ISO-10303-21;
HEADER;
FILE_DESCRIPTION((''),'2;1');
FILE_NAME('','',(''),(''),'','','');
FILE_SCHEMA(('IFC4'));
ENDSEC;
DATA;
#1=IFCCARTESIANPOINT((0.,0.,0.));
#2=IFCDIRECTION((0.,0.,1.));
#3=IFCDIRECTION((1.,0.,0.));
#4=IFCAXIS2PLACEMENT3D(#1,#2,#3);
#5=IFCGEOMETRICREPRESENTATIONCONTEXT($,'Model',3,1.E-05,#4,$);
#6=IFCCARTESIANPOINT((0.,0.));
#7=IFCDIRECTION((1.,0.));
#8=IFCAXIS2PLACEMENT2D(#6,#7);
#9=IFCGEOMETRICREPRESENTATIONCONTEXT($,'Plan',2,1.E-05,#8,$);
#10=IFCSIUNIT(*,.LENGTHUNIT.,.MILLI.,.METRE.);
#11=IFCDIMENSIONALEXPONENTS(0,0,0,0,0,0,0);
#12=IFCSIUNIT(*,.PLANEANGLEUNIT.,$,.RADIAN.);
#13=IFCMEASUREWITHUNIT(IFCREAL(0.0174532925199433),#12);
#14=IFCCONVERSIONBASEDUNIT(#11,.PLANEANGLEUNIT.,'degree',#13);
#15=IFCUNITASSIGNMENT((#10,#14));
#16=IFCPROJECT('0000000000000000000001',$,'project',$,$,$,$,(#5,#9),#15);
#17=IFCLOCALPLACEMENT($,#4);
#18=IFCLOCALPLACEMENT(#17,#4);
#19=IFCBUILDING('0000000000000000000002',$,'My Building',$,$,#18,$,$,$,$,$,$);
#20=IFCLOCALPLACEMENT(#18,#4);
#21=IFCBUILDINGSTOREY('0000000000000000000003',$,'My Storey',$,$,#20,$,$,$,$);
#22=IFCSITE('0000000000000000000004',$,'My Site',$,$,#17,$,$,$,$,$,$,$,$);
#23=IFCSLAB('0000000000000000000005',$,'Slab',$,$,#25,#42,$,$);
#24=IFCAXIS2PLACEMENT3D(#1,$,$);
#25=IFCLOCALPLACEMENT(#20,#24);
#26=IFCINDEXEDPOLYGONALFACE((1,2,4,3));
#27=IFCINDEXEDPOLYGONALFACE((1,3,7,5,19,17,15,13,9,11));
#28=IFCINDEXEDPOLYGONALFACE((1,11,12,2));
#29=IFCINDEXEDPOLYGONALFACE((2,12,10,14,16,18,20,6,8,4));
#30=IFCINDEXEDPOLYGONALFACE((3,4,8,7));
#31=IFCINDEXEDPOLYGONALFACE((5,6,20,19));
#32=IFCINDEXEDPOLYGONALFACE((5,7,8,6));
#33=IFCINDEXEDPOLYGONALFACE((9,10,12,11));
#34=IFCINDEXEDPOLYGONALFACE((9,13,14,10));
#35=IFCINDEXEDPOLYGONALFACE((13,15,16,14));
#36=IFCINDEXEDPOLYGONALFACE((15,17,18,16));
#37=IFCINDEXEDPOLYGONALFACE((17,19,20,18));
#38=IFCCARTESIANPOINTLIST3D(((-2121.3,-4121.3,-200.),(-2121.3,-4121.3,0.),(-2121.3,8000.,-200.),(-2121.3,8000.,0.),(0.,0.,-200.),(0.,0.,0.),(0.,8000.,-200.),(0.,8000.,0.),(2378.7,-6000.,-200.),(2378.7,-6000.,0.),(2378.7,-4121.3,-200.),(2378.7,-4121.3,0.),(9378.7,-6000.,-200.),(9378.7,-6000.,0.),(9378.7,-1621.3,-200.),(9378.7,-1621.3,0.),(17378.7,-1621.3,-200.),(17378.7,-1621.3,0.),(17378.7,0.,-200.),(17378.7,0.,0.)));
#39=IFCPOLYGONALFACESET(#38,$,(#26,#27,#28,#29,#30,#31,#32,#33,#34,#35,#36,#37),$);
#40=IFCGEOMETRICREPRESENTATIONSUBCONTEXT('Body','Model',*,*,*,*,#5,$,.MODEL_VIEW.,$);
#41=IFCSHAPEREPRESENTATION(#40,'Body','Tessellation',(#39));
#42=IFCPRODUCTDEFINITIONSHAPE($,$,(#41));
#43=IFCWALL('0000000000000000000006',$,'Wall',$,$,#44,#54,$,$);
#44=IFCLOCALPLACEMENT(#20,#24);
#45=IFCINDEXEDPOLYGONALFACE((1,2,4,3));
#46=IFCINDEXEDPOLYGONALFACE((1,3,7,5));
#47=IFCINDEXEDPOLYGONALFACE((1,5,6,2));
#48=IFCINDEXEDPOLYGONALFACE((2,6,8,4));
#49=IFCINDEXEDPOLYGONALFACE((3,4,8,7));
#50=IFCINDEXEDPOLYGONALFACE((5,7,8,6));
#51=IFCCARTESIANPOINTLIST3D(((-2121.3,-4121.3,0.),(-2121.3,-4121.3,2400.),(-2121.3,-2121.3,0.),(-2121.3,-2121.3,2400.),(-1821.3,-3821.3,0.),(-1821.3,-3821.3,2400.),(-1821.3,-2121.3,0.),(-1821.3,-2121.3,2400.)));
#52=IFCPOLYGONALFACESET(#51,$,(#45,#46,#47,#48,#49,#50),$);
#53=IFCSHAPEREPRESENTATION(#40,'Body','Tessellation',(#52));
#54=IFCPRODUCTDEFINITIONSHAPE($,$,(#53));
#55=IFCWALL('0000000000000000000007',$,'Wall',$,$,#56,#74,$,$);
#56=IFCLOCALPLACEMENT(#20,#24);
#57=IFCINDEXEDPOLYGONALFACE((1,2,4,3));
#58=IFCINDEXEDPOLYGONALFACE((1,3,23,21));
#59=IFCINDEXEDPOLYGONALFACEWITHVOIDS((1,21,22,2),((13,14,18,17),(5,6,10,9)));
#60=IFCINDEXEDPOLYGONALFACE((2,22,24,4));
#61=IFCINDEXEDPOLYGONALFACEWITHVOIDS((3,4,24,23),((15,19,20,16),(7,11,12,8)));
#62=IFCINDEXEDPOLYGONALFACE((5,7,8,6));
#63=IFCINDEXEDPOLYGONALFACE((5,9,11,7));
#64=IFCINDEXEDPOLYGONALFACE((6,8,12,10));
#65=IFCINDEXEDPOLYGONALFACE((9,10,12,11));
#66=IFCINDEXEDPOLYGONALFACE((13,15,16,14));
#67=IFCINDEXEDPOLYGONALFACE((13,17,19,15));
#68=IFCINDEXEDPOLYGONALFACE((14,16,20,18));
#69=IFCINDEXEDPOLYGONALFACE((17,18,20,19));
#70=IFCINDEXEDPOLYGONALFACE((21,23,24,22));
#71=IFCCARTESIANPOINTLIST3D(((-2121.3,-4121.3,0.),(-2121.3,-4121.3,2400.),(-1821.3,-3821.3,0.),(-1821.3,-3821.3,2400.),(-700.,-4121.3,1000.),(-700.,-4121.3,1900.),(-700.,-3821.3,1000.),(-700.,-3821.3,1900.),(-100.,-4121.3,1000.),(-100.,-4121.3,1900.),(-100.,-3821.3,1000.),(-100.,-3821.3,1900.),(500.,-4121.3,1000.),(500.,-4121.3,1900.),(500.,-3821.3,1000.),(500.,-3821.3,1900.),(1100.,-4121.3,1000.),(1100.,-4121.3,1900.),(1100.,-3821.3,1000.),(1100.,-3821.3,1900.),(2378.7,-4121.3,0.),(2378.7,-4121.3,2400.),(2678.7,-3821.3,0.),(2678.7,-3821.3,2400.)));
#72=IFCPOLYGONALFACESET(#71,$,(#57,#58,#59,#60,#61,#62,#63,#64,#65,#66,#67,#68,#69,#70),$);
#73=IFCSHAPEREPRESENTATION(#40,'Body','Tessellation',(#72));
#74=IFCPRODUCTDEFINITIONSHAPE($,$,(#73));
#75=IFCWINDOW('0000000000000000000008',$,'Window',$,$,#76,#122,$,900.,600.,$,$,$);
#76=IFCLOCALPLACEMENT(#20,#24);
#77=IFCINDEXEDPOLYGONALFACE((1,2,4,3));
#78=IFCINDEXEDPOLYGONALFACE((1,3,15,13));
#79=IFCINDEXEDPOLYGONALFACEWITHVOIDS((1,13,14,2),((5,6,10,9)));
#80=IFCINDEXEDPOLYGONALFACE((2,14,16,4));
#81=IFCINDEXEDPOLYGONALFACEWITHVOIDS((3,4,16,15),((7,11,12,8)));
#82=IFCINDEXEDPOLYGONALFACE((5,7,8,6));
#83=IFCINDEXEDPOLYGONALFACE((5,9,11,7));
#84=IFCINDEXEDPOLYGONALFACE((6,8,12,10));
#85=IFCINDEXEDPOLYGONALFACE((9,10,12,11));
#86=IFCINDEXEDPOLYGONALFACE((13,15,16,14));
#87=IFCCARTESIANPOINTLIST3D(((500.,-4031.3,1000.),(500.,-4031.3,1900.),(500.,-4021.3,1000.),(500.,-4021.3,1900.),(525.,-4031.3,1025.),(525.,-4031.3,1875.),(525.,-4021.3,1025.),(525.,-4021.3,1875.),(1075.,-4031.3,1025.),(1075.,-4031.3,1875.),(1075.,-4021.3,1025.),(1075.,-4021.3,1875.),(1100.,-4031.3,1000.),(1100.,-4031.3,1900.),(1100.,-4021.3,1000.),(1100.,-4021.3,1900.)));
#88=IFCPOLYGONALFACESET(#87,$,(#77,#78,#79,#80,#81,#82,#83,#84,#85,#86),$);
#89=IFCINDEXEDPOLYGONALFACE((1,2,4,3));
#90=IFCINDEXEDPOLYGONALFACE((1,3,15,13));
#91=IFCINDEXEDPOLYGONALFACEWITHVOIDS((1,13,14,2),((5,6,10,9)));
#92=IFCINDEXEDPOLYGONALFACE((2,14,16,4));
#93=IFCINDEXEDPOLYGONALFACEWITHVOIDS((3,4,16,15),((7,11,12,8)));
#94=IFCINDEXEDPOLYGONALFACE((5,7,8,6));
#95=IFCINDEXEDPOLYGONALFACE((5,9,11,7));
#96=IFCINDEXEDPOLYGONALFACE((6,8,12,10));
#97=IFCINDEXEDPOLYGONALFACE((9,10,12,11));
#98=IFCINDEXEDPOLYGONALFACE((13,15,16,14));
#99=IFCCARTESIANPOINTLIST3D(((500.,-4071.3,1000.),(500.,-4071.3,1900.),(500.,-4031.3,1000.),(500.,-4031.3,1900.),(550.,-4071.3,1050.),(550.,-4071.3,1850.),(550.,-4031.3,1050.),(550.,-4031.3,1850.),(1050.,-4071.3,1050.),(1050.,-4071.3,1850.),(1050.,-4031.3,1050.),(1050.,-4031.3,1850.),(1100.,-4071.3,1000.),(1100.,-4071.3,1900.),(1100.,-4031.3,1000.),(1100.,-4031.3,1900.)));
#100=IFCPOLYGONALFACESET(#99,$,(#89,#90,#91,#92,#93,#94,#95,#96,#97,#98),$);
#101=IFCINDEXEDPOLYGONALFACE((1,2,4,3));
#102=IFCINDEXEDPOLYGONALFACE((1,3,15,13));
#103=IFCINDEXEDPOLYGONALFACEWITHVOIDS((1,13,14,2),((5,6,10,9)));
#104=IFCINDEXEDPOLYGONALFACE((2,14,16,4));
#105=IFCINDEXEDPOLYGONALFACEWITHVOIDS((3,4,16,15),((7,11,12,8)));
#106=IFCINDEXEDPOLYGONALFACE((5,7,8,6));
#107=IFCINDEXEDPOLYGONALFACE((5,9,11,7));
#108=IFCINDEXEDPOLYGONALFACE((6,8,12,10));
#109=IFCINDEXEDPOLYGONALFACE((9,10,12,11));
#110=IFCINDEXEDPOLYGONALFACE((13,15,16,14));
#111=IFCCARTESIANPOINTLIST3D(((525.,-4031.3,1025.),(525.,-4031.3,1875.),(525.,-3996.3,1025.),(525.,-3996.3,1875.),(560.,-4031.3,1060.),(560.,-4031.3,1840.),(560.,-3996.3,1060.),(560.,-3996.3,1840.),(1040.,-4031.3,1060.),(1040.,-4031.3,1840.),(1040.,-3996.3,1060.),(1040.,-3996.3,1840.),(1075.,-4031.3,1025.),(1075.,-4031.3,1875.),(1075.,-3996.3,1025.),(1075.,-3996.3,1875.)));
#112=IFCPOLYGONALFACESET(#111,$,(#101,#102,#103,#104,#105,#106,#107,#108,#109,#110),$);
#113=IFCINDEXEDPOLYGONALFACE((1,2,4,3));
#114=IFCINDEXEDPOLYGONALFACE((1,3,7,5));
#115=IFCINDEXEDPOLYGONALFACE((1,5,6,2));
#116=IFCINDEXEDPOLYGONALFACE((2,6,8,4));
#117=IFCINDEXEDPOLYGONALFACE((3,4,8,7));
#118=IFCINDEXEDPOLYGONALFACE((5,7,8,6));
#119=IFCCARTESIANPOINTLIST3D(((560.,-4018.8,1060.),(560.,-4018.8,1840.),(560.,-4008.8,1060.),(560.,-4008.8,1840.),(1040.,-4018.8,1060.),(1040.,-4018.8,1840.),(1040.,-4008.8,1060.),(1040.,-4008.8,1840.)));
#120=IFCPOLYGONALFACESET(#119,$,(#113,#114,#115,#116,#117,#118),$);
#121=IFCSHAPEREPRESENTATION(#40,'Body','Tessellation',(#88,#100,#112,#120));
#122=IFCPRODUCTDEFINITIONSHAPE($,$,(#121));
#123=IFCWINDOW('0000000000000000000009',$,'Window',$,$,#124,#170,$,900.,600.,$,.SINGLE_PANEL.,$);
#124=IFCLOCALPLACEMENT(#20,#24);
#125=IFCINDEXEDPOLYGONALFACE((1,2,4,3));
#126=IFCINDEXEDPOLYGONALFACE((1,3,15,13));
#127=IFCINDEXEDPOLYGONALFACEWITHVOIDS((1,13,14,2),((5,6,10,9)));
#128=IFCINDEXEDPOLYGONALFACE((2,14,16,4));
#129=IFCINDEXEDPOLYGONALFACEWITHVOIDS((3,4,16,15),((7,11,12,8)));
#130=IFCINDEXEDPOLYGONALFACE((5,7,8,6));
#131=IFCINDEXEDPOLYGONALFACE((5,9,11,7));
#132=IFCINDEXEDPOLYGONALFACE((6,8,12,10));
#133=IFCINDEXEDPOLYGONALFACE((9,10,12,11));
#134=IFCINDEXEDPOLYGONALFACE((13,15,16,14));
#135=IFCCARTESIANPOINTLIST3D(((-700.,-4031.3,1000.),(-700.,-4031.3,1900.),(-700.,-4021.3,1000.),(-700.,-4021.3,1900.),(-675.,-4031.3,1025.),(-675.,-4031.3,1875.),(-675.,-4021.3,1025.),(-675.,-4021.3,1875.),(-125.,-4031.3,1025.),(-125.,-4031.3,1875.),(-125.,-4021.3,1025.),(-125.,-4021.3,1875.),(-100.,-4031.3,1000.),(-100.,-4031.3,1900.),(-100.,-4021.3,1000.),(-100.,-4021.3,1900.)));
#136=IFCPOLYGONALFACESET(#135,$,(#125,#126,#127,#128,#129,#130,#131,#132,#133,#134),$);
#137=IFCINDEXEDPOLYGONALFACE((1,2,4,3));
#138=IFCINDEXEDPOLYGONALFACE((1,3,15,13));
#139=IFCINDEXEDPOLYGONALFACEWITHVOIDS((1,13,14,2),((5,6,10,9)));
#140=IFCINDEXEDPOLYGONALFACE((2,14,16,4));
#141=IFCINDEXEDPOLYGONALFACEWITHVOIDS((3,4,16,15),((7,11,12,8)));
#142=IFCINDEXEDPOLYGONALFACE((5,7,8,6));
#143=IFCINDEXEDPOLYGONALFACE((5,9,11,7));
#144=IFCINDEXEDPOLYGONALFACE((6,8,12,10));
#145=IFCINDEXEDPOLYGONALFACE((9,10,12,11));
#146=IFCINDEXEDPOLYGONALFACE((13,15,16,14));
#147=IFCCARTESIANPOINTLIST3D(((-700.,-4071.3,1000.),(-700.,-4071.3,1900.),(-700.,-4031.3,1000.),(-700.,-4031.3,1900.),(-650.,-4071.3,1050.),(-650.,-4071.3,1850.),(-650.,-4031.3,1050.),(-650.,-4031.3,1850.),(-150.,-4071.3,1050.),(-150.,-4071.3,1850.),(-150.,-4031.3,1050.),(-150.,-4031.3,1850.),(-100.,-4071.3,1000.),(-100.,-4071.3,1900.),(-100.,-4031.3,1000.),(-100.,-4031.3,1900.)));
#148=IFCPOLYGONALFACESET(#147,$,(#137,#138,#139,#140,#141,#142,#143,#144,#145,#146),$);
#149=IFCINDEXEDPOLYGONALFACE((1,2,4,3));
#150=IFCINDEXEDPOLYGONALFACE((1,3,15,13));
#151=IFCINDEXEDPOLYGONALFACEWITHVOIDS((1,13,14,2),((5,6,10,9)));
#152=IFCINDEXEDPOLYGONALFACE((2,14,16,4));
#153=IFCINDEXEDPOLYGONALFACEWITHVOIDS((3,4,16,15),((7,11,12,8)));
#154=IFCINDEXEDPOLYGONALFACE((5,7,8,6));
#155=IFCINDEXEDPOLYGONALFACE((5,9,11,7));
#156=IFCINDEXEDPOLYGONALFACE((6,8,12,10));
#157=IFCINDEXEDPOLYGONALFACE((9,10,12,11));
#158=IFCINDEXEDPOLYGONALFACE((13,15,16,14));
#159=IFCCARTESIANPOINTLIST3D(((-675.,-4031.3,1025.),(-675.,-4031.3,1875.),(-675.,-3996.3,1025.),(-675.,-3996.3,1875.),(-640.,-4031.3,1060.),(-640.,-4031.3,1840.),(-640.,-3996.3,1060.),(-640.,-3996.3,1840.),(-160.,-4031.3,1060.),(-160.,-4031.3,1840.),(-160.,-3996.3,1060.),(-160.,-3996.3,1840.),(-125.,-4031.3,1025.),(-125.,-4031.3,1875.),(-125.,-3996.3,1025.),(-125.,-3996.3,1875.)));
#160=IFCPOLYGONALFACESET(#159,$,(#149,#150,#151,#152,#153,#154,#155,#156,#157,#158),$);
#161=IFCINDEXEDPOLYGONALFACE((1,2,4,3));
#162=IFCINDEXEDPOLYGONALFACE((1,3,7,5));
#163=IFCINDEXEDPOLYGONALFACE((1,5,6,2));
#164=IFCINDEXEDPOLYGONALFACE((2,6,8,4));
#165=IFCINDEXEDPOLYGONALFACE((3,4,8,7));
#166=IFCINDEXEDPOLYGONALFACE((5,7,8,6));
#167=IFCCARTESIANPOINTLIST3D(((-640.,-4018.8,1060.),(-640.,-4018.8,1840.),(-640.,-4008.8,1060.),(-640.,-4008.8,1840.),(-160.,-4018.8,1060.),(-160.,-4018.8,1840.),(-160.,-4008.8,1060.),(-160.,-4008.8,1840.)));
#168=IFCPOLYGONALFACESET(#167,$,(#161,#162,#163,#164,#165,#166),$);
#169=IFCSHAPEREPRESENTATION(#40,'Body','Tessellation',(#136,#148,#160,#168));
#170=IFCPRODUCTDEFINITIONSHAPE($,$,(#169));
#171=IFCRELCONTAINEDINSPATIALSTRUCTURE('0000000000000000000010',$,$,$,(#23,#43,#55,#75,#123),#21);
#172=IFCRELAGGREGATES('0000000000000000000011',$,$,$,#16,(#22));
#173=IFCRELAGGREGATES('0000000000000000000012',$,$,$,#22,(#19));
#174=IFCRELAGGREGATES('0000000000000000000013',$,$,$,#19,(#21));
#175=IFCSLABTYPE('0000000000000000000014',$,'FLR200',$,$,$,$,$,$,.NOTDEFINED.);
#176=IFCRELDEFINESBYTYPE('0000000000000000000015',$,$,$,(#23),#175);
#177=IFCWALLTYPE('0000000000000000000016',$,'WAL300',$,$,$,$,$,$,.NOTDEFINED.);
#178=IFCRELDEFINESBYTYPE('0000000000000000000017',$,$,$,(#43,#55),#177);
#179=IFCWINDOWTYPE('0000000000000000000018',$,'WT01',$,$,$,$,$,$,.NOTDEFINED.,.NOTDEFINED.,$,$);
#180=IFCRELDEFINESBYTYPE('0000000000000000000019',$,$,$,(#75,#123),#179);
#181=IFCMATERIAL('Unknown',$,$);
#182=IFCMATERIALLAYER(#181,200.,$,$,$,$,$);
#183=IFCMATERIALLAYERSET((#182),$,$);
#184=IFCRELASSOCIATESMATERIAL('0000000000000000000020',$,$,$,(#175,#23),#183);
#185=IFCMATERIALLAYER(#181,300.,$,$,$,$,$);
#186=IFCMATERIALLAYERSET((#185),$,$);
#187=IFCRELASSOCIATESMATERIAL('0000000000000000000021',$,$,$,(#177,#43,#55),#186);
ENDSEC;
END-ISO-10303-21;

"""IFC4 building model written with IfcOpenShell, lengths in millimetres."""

from ifc_helpers import new_model, entity, si_unit, converted_unit, frame, origin_with_axes, origin_2d_with_axis, place, context, subcontext, project, spatial, line, indexed_curve, outline, extrude, shape, source, transform, mapped, material, layer, layer_set, layer_usage, type_object, type_shapes, element, fill, save


model = new_model("IFC4")

# Units and contexts
model_context = context("Model", 3, precision=1e-05, world=origin_with_axes())
plan_context = context("Plan", 2, precision=1e-05, world=origin_2d_with_axis())
body_context_1 = subcontext(model_context, "Body", "Model", "MODEL_VIEW")
body_context_2 = subcontext(plan_context, "Body", "Plan", "PLAN_VIEW")
ifc_project = project(units=[si_unit("LENGTHUNIT", "METRE", prefix="MILLI"), converted_unit("PLANEANGLEUNIT", "degree", entity("IfcReal", 0.0174532925199433), si_unit("PLANEANGLEUNIT", "RADIAN"), dimensions=[0, 0, 0, 0, 0, 0, 0])], contexts=[model_context, plan_context])

# Site, building, storey
site_placement = place(None, origin_with_axes())
site = spatial("IfcSite", under=ifc_project, at=site_placement, Name="My Site")
building_placement = place(site_placement, origin_with_axes())
building = spatial("IfcBuilding", under=site, at=building_placement, Name="My Building")
storey_placement = place(building_placement, origin_with_axes())
storey = spatial("IfcBuildingStorey", under=building, at=storey_placement, Name="My Storey")

# Shared definitions
ifc_material = material(Name="Unknown")

# Slab
ifc_layer_1 = layer(ifc_material, 200.0)
ifc_layer_set_1 = layer_set([ifc_layer_1])
ifc_layer_usage_1 = layer_usage(ifc_layer_set_1, "AXIS3", "POSITIVE", -200.0)
slab_type = type_object("IfcSlabType", Name="FLR200", PredefinedType="NOTDEFINED", material=ifc_layer_set_1)
slab_placement = place(storey_placement, frame((0.0, 8000.0, 0.0), z_axis=(0.0, 0.0, 1.0), x_axis=(1.0, 0.0, 0.0)))
element("IfcSlab", 1, at=slab_placement, inside=storey, type_object=slab_type, material=ifc_layer_usage_1, Name="Slab", context=body_context_1, shape_type="SweptSolid", body=[
    extrude(outline(indexed_curve([(0.0, 0.0), (-2121.3, 0.0), (-2121.3, -12121.3), (2378.7, -12121.3), (2378.7, -14000.0), (9378.7, -14000.0), (9378.7, -9621.3), (17378.7, -9621.3), (17378.7, -8000.0), (0.0, -8000.0), (0.0, 0.0)])), frame((0.0, 0.0, -200.0), z_axis=(0.0, 0.0, 1.0), x_axis=(1.0, 0.0, 0.0)), (0.0, 0.0, 1.0), 200.0),
])

# Wall
ifc_layer_2 = layer(ifc_material, 300.0)
ifc_layer_set_2 = layer_set([ifc_layer_2])
ifc_layer_usage_2 = layer_usage(ifc_layer_set_2, "AXIS2", "POSITIVE", 0.0)
wall_type = type_object("IfcWallType", Name="WAL300", PredefinedType="NOTDEFINED", material=ifc_layer_set_2)
wall_1_placement = place(storey_placement, frame((-2121.3, -2121.3, 0.0), z_axis=(0.0, 0.0, 1.0), x_axis=(0.0, -1.0, 0.0)))
element("IfcWall", 2, at=wall_1_placement, inside=storey, type_object=wall_type, material=ifc_layer_usage_2, Name="Wall", context=body_context_1, shape_type="SweptSolid", body=[
    extrude(outline(indexed_curve([(0.0, 0.0), (0.0, 300.0), (1700.0, 300.0), (2000.0, 0.0)], segments=[line(1, 2, 3, 4, 1)])), origin_with_axes(), (0.0, 0.0, 1.0), 2400.0),
])

# Wall, openings, windows
ifc_layer_usage_3 = layer_usage(ifc_layer_set_2, "AXIS2", "POSITIVE", 0.0)
wall_2_placement = place(storey_placement, frame((-2121.3, -4121.3, 0.0), z_axis=(0.0, 0.0, 1.0), x_axis=(1.0, 0.0, 0.0)))
wall_2 = element("IfcWall", 3, at=wall_2_placement, inside=storey, type_object=wall_type, material=ifc_layer_usage_3, Name="Wall", context=body_context_1, shape_type="SweptSolid", body=[
    extrude(outline(indexed_curve([(0.0, 0.0), (300.0, 300.0), (4800.0, 300.0), (4500.0, 0.0)], segments=[line(1, 2, 3, 4, 1)])), origin_with_axes(), (0.0, 0.0, 1.0), 2400.0),
])
shared_shape_1 = source(origin_with_axes(), body_context_1, "Body", "SweptSolid", [
    extrude(outline(indexed_curve([(0.0, 0.0), (600.0, 0.0), (600.0, 900.0), (0.0, 900.0)], segments=[line(1, 2, 3, 4, 1)])), frame((0.0, -600.0, 0.0), z_axis=(0.0, -1.0, 0.0), x_axis=(1.0, 0.0, 0.0)), (0.0, 0.0, -1.0), 1200.0),
])
opening_1_placement = place(wall_2_placement, frame((2621.3, 0.0, 1000.0), z_axis=(0.0, 0.0, 1.0), x_axis=(1.0, 0.0, 0.0)))
opening_1 = element("IfcOpeningElement", 4, at=opening_1_placement, cuts=wall_2, PredefinedType="OPENING", context=body_context_1, shape_type="MappedRepresentation", body=[
    mapped(shared_shape_1, transform((0.0, 0.0, 0.0), x_axis=(1.0, 0.0, 0.0), y_axis=(0.0, 1.0, 0.0), z_axis=(0.0, 0.0, 1.0), scale=1.0)),
])
opening_2_placement = place(wall_2_placement, frame((1421.3, 0.0, 1000.0), z_axis=(0.0, 0.0, 1.0), x_axis=(1.0, 0.0, 0.0)))
opening_2 = element("IfcOpeningElement", 5, at=opening_2_placement, cuts=wall_2, PredefinedType="OPENING", context=body_context_1, shape_type="MappedRepresentation", body=[
    mapped(shared_shape_1, transform((0.0, 0.0, 0.0), x_axis=(1.0, 0.0, 0.0), y_axis=(0.0, 1.0, 0.0), z_axis=(0.0, 0.0, 1.0), scale=1.0)),
])
window_type = type_object("IfcWindowType", Name="WT01", PartitioningType="NOTDEFINED", PredefinedType="NOTDEFINED")
shared_shape_2 = source(origin_with_axes(), body_context_1, "Body", "SweptSolid", [
    extrude(outline(indexed_curve([(0.0, 0.0), (600.0, 0.0), (600.0, 900.0), (0.0, 900.0)], segments=[line(1, 2, 3, 4, 1)]), holes=[indexed_curve([(25.0, 25.0), (575.0, 25.0), (575.0, 875.0), (25.0, 875.0)], segments=[line(1, 2, 3, 4, 1)])]), frame((0.0, 90.0, 0.0), z_axis=(0.0, -1.0, 0.0), x_axis=(1.0, 0.0, 0.0)), (0.0, 0.0, -1.0), 10.0),
    extrude(outline(indexed_curve([(0.0, 0.0), (600.0, 0.0), (600.0, 900.0), (0.0, 900.0)], segments=[line(1, 2, 3, 4, 1)]), holes=[indexed_curve([(50.0, 50.0), (550.0, 50.0), (550.0, 850.0), (50.0, 850.0)], segments=[line(1, 2, 3, 4, 1)])]), frame((0.0, 50.0, 0.0), z_axis=(0.0, -1.0, 0.0), x_axis=(1.0, 0.0, 0.0)), (0.0, 0.0, -1.0), 40.0),
    extrude(outline(indexed_curve([(0.0, 0.0), (550.0, 0.0), (550.0, 850.0), (0.0, 850.0), (0.0, 0.0)]), holes=[indexed_curve([(35.0, 35.0), (515.0, 35.0), (515.0, 815.0), (35.0, 815.0), (35.0, 35.0)])]), frame((25.0, 90.0, 25.0), z_axis=(0.0, -1.0, 0.0), x_axis=(1.0, 0.0, 0.0)), (0.0, 0.0, -1.0), 35.0),
    extrude(outline(indexed_curve([(35.0, 815.0), (515.0, 815.0), (515.0, 35.0), (35.0, 35.0), (35.0, 815.0)])), frame((25.0, 102.5, 25.0), z_axis=(0.0, -1.0, 0.0), x_axis=(1.0, 0.0, 0.0)), (0.0, 0.0, -1.0), 10.0),
])
shared_shape_3 = source(origin_with_axes(), body_context_2, "Body", "Curve2D", [
    entity("IfcIndexedPolyCurve", entity("IfcCartesianPointList2D", [[50.0, 50.0], [550.0, 50.0]])),
    entity("IfcIndexedPolyCurve", entity("IfcCartesianPointList2D", [[0.0, 100.0], [25.0, 100.0], [25.0, 90.0], [50.0, 90.0], [50.0, 50.0], [0.0, 50.0]]), [entity("IfcLineIndex", [1, 2, 3, 4, 5, 6, 1])]),
    entity("IfcIndexedPolyCurve", entity("IfcCartesianPointList2D", [[600.0, 100.0], [575.0, 100.0], [575.0, 90.0], [550.0, 90.0], [550.0, 50.0], [600.0, 50.0]]), [entity("IfcLineIndex", [1, 2, 3, 4, 5, 6, 1])]),
    entity("IfcIndexedPolyCurve", entity("IfcCartesianPointList2D", [[25.0, 90.0], [60.0, 90.0], [60.0, 125.0], [25.0, 125.0]]), [entity("IfcLineIndex", [1, 2, 3, 4, 1])]),
    entity("IfcIndexedPolyCurve", entity("IfcCartesianPointList2D", [[575.0, 90.0], [540.0, 90.0], [540.0, 125.0], [575.0, 125.0]]), [entity("IfcLineIndex", [1, 2, 3, 4, 1])]),
    entity("IfcIndexedPolyCurve", entity("IfcCartesianPointList2D", [[60.0, 90.0], [540.0, 90.0]])),
    entity("IfcIndexedPolyCurve", entity("IfcCartesianPointList2D", [[60.0, 125.0], [540.0, 125.0]])),
    entity("IfcIndexedPolyCurve", entity("IfcCartesianPointList2D", [[60.0, 107.5], [540.0, 107.5]])),
])
type_shapes(window_type, [shared_shape_2, shared_shape_3])
window_1_placement = place(opening_1_placement, frame((0.0, 0.0, 0.0), z_axis=(0.0, 0.0, 1.0), x_axis=(1.0, 0.0, 0.0)))
window_1 = element("IfcWindow", 6, at=window_1_placement, inside=storey, type_object=window_type, Name="Window", OverallHeight=900.0, OverallWidth=600.0, shapes=[
    shape(body_context_1, "Body", "MappedRepresentation", [mapped(shared_shape_2, transform((0.0, 0.0, 0.0), x_axis=(1.0, 0.0, 0.0), y_axis=(0.0, 1.0, 0.0), z_axis=(0.0, 0.0, 1.0), scale=1.0))]),
    shape(body_context_2, "Body", "MappedRepresentation", [mapped(shared_shape_3, transform((0.0, 0.0, 0.0), x_axis=(1.0, 0.0, 0.0), y_axis=(0.0, 1.0, 0.0), z_axis=(0.0, 0.0, 1.0), scale=1.0))]),
])
fill(opening_1, window_1)
window_2_placement = place(opening_2_placement, origin_with_axes())
window_2 = element("IfcWindow", 7, at=window_2_placement, inside=storey, type_object=window_type, Name="Window", OverallHeight=900.0, OverallWidth=600.0, PartitioningType="SINGLE_PANEL", shapes=[
    shape(body_context_1, "Body", "MappedRepresentation", [mapped(shared_shape_2, transform((0.0, 0.0, 0.0), x_axis=(1.0, 0.0, 0.0), y_axis=(0.0, 1.0, 0.0), z_axis=(0.0, 0.0, 1.0), scale=1.0))]),
    shape(body_context_2, "Body", "MappedRepresentation", [mapped(shared_shape_3, transform((0.0, 0.0, 0.0), x_axis=(1.0, 0.0, 0.0), y_axis=(0.0, 1.0, 0.0), z_axis=(0.0, 0.0, 1.0), scale=1.0))]),
])
fill(opening_2, window_2)

save(model, "model.ifc")
